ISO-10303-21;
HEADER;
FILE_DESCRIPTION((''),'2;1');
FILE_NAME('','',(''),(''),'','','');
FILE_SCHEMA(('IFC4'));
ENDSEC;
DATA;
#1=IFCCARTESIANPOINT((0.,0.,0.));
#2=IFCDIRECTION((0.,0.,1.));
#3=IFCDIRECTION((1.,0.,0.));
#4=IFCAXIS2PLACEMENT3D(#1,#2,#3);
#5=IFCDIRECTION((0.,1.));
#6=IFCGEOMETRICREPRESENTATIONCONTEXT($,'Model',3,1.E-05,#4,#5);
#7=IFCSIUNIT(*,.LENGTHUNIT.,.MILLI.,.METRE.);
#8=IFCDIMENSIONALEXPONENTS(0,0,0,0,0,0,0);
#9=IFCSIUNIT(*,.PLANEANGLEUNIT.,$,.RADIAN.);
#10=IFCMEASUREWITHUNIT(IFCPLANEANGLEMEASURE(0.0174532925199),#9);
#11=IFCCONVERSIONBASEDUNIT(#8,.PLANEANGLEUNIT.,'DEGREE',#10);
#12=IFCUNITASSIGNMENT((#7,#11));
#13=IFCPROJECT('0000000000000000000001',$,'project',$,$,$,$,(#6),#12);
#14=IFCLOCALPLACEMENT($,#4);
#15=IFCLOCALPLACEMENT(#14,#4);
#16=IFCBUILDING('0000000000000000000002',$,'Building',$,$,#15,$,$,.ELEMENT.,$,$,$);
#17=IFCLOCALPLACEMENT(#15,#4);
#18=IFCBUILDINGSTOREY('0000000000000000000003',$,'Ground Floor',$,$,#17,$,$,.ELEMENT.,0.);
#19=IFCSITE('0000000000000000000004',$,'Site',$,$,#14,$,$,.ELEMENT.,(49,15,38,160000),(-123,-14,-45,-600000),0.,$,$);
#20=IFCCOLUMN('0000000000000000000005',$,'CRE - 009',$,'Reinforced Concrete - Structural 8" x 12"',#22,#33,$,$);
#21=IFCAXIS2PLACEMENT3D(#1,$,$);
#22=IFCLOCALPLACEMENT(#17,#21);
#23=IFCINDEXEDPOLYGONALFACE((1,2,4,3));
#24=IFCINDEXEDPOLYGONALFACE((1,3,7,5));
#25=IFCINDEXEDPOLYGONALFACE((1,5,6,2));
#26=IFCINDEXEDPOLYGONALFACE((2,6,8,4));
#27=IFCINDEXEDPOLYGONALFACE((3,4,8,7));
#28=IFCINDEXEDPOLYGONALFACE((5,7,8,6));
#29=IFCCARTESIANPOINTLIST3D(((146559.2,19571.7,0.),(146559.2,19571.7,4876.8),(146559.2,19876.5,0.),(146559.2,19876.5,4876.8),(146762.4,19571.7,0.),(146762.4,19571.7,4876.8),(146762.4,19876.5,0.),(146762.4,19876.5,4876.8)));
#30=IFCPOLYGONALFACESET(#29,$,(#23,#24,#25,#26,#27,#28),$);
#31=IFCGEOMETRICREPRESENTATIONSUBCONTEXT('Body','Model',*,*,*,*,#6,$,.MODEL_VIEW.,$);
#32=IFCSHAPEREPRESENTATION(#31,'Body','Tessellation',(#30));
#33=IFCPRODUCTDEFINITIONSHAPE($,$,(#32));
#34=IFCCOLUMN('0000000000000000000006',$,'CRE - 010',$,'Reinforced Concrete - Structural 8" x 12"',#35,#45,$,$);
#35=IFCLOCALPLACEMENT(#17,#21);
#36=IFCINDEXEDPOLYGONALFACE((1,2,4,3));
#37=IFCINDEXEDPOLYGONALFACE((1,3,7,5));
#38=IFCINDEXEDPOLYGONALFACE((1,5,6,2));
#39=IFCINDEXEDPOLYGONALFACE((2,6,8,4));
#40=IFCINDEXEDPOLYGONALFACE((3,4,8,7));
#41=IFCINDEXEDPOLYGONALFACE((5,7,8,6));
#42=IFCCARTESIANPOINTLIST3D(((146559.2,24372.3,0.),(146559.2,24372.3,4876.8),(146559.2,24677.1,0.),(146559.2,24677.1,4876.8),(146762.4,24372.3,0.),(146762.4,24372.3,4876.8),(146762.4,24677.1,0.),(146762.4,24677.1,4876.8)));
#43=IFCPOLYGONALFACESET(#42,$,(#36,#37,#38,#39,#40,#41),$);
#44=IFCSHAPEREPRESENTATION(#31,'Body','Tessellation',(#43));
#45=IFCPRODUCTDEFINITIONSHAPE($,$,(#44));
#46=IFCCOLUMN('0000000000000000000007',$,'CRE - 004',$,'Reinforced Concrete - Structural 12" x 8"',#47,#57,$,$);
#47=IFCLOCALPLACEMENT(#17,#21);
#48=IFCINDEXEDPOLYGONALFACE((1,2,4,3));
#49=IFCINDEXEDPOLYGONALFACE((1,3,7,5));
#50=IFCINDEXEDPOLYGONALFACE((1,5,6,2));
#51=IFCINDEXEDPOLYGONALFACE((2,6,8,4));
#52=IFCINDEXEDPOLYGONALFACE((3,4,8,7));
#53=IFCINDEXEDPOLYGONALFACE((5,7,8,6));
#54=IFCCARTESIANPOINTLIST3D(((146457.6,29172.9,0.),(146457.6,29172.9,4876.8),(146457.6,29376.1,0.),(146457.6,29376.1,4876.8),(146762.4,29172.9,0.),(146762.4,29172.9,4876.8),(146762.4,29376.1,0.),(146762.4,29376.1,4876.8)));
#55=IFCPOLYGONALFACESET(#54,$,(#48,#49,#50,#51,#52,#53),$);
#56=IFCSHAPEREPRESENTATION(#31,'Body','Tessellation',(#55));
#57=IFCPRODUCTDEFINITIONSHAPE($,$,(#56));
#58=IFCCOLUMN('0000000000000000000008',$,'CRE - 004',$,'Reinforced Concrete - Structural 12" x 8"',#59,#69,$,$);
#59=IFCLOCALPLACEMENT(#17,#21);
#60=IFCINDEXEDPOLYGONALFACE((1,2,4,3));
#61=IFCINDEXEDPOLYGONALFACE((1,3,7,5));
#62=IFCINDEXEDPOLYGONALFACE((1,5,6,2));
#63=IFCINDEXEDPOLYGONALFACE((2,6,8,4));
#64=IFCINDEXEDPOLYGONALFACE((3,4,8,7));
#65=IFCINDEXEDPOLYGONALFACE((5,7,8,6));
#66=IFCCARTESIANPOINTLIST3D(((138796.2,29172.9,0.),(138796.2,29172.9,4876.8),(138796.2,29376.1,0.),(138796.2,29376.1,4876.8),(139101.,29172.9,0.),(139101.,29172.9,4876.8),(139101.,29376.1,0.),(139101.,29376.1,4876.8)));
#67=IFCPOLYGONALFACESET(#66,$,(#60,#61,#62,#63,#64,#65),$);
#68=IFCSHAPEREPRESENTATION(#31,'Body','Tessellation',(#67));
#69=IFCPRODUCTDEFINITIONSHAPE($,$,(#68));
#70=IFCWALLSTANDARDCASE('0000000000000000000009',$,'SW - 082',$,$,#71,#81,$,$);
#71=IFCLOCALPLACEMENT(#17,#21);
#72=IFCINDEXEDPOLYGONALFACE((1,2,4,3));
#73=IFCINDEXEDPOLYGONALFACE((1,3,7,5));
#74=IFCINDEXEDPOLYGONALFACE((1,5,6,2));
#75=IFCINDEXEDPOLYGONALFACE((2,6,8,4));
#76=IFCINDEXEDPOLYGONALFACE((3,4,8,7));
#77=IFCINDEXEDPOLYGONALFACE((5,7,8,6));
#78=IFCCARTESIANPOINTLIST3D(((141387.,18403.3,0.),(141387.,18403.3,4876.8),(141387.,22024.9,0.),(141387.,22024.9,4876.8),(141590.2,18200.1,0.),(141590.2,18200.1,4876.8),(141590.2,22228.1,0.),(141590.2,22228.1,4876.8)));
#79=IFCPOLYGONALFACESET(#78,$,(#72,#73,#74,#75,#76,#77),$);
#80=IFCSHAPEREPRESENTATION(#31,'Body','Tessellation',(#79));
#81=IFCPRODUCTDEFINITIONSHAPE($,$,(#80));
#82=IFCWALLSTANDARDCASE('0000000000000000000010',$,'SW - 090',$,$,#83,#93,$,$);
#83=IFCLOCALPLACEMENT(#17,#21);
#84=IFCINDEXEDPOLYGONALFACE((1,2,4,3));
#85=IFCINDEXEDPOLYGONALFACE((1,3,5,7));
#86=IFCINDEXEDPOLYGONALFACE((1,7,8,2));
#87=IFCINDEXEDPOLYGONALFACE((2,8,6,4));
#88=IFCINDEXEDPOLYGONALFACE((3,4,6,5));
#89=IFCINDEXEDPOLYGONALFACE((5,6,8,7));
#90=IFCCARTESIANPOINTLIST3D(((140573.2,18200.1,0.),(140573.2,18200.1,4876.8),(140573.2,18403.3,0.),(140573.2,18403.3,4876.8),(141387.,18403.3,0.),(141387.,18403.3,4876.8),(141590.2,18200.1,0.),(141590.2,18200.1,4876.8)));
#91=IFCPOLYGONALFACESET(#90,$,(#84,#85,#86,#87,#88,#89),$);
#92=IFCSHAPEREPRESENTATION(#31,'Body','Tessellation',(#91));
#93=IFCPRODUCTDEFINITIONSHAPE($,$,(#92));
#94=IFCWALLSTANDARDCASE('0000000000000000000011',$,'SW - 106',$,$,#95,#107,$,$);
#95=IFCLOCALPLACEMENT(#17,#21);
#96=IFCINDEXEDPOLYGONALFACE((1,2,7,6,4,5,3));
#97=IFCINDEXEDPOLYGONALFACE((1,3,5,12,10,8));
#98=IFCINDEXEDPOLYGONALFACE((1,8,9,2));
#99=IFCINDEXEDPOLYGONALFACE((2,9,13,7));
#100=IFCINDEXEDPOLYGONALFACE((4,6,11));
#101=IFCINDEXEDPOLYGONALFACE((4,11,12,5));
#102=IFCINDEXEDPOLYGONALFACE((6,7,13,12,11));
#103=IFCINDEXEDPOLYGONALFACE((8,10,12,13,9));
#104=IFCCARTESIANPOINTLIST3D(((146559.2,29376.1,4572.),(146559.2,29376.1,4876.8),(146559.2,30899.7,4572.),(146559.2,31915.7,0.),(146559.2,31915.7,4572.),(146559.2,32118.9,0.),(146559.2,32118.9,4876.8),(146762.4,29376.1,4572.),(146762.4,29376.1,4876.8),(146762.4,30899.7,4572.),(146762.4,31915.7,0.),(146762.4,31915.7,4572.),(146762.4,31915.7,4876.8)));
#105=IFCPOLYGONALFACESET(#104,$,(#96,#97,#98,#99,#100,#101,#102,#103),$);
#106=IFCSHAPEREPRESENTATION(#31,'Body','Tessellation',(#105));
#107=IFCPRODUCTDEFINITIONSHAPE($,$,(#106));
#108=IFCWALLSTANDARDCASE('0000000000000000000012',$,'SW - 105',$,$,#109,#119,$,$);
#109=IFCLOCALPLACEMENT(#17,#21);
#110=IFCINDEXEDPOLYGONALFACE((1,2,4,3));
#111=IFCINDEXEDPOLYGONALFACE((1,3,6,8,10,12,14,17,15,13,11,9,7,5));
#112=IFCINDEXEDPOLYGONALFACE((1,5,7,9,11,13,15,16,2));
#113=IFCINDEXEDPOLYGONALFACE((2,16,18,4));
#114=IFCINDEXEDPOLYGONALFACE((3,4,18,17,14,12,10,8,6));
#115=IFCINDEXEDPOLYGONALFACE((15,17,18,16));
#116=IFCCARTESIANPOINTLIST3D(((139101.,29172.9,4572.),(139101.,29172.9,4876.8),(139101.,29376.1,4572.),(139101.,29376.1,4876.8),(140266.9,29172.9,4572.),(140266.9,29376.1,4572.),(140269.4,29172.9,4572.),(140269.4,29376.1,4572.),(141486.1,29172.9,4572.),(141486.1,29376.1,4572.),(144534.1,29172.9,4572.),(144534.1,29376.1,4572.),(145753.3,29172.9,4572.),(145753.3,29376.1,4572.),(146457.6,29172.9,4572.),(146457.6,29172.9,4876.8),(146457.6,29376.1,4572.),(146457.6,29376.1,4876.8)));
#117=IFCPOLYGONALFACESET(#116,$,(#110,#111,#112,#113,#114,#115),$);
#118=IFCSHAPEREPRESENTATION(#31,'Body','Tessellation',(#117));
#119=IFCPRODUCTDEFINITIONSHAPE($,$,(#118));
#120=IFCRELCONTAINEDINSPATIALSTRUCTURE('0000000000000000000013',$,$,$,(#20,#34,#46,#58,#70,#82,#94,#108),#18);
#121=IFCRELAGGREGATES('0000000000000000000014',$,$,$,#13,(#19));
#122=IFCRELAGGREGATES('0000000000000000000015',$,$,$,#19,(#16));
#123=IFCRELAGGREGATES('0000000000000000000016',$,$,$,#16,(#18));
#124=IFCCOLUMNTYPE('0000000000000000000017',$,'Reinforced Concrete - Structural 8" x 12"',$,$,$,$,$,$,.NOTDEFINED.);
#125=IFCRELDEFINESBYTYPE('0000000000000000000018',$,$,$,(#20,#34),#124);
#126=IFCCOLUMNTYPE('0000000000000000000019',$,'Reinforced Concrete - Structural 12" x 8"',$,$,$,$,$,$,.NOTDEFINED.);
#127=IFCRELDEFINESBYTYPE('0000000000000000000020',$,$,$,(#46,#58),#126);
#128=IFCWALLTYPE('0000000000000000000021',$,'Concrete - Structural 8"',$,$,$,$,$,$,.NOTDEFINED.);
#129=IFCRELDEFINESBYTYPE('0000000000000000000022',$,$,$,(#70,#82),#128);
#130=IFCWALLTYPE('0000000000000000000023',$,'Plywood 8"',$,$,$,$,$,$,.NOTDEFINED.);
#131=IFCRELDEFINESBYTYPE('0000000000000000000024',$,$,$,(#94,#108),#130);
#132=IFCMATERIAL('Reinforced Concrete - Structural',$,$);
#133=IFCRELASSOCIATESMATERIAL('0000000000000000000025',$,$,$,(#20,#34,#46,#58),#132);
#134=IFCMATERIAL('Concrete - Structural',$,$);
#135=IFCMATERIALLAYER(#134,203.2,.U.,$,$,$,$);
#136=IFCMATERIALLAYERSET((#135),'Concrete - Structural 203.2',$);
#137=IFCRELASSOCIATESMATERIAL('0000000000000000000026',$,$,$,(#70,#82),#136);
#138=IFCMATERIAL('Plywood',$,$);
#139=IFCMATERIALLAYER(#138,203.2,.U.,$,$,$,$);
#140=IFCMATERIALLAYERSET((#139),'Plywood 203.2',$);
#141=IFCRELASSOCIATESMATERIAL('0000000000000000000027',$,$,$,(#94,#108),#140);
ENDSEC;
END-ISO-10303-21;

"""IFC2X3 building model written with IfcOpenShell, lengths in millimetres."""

from ifc_helpers import new_model, entity, si_unit, converted_unit, direction, frame, origin_with_axes, origin_2d_with_axis, place, context, subcontext, project, spatial, polyline, rectangle, outline, extrude, material, layer, layer_set, layer_usage, type_object, element, save


model = new_model("IFC2X3")

# Units and contexts
model_context = context("Model", 3, precision=1e-05, world=origin_with_axes(), true_north=direction((0.0, 1.0)))
body_context = subcontext(model_context, "Body", "Model", "MODEL_VIEW")
ifc_project = project(units=[si_unit("LENGTHUNIT", "METRE", prefix="MILLI"), converted_unit("PLANEANGLEUNIT", "DEGREE", entity("IfcPlaneAngleMeasure", 0.0174532925199), si_unit("PLANEANGLEUNIT", "RADIAN"), dimensions=[0, 0, 0, 0, 0, 0, 0])], contexts=[model_context])

# Site, building, storey
site_placement = place(None, origin_with_axes())
site = spatial("IfcSite", under=ifc_project, at=site_placement, Name="Site", CompositionType="ELEMENT", RefLatitude=(49, 15, 38, 160000), RefLongitude=(-123, -14, -45, -600000), RefElevation=0.0)
building_placement = place(site_placement, origin_with_axes())
building = spatial("IfcBuilding", under=site, at=building_placement, Name="Building", CompositionType="ELEMENT")
storey_placement = place(building_placement, origin_with_axes())
storey = spatial("IfcBuildingStorey", under=building, at=storey_placement, Name="Ground Floor", CompositionType="ELEMENT", Elevation=0.0)

# Columns
ifc_material_1 = material(Name="Reinforced Concrete - Structural")
column_type_1 = type_object("IfcColumnType", Name="Reinforced Concrete - Structural 8\" x 12\"", PredefinedType="NOTDEFINED")
for number, where, z_axis, x_axis, name in (
    (1, (146660.8, 19724.1, 0.0), (0.0, 0.0, 1.0), (1.0, 0.0, 0.0), "CRE - 009"),
    (2, (146660.8, 24524.7, 0.0), (0.0, 0.0, 1.0), (1.0, 0.0, 0.0), "CRE - 010"),
):
    element("IfcColumn", number, at=place(storey_placement, frame(where, z_axis=z_axis, x_axis=x_axis)), inside=storey, type_object=column_type_1, material=ifc_material_1, Name=name, ObjectType="Reinforced Concrete - Structural 8\" x 12\"", context=body_context, shape_type="SweptSolid", body=[
        extrude(rectangle(XDim=203.2, YDim=304.8, at=origin_2d_with_axis()), origin_with_axes(), (0.0, 0.0, 1.0), 4876.8),
    ])
column_type_2 = type_object("IfcColumnType", Name="Reinforced Concrete - Structural 12\" x 8\"", PredefinedType="NOTDEFINED")
for number, where, z_axis, x_axis, name in (
    (3, (146610.0, 29274.5, 0.0), (0.0, 0.0, 1.0), (1.0, 0.0, 0.0), "CRE - 004"),
    (4, (138948.6, 29274.5, 0.0), (0.0, 0.0, 1.0), (1.0, 0.0, 0.0), "CRE - 004"),
):
    element("IfcColumn", number, at=place(storey_placement, frame(where, z_axis=z_axis, x_axis=x_axis)), inside=storey, type_object=column_type_2, material=ifc_material_1, Name=name, ObjectType="Reinforced Concrete - Structural 12\" x 8\"", context=body_context, shape_type="SweptSolid", body=[
        extrude(rectangle(XDim=304.8, YDim=203.2, at=origin_2d_with_axis()), origin_with_axes(), (0.0, 0.0, 1.0), 4876.8),
    ])

# Walls
ifc_material_2 = material(Name="Concrete - Structural")
ifc_layer_1 = layer(ifc_material_2, 203.2, ventilated="UNKNOWN")
ifc_layer_set_1 = layer_set([ifc_layer_1], Name="Concrete - Structural 203.2")
ifc_layer_usage_1 = layer_usage(ifc_layer_set_1, "AXIS2", "POSITIVE", 0.0)
wall_type_1 = type_object("IfcWallType", Name="Concrete - Structural 8\"", PredefinedType="NOTDEFINED")
wall_1_placement = place(storey_placement, frame((141387.0, 22024.9, 0.0), z_axis=(0.0, 0.0, 1.0), x_axis=(0.0, -1.0, 0.0)))
element("IfcWallStandardCase", 5, at=wall_1_placement, inside=storey, type_object=wall_type_1, material=ifc_layer_usage_1, Name="SW - 082", context=body_context, shape_type="SweptSolid", body=[
    extrude(outline(polyline([(0.0, 0.0), (3621.6, 0.0), (3824.8, 203.2), (-203.2, 203.2), (0.0, 0.0)])), origin_with_axes(), (0.0, 0.0, 1.0), 4876.8),
])
ifc_layer_usage_2 = layer_usage(ifc_layer_set_1, "AXIS2", "POSITIVE", 0.0)
wall_2_placement = place(storey_placement, frame((141387.0, 18403.3, 0.0), z_axis=(0.0, 0.0, 1.0), x_axis=(-1.0, 0.0, 0.0)))
element("IfcWallStandardCase", 6, at=wall_2_placement, inside=storey, type_object=wall_type_1, material=ifc_layer_usage_2, Name="SW - 090", context=body_context, shape_type="SweptSolid", body=[
    extrude(outline(polyline([(0.0, 0.0), (813.8, 0.0), (813.8, 203.2), (-203.2, 203.2), (0.0, 0.0)])), origin_with_axes(), (0.0, 0.0, 1.0), 4876.8),
])

# Walls, openings
ifc_material_3 = material(Name="Plywood")
ifc_layer_2 = layer(ifc_material_3, 203.2, ventilated="UNKNOWN")
ifc_layer_set_2 = layer_set([ifc_layer_2], Name="Plywood 203.2")
ifc_layer_usage_3 = layer_usage(ifc_layer_set_2, "AXIS2", "POSITIVE", 0.0)
wall_type_2 = type_object("IfcWallType", Name="Plywood 8\"", PredefinedType="NOTDEFINED")
wall_3_placement = place(storey_placement, frame((146762.4, 29376.1, 0.0), z_axis=(0.0, 0.0, 1.0), x_axis=(0.0, 1.0, 0.0)))
wall_3 = element("IfcWallStandardCase", 7, at=wall_3_placement, inside=storey, type_object=wall_type_2, material=ifc_layer_usage_3, Name="SW - 106", context=body_context, shape_type="SweptSolid", body=[
    extrude(outline(polyline([(0.0, 0.0), (2539.7, 0.0), (2742.9, 203.2), (0.0, 203.2), (0.0, 0.0)])), origin_with_axes(), (0.0, 0.0, 1.0), 4876.8),
])
opening_1_placement = place(wall_3_placement, frame((2031.7, 0.0, 0.0), z_axis=(0.0, 0.0, 1.0), x_axis=(1.0, 0.0, 0.0)))
element("IfcOpeningElement", 8, at=opening_1_placement, cuts=wall_3, context=body_context, shape_type="SweptSolid", body=[
    extrude(rectangle(XDim=1016.0, YDim=4572.0, at=origin_2d_with_axis()), frame((0.0, -203.2, 2286.0), z_axis=(0.0, -1.0, 0.0), x_axis=(-1.0, 0.0, 0.0)), (0.0, 0.0, -1.0), 609.6),
])
opening_2_placement = place(wall_3_placement, frame((761.8, 0.0, 0.0), z_axis=(0.0, 0.0, 1.0), x_axis=(1.0, 0.0, 0.0)))
element("IfcOpeningElement", 9, at=opening_2_placement, cuts=wall_3, context=body_context, shape_type="SweptSolid", body=[
    extrude(rectangle(XDim=1523.7, YDim=4572.0, at=origin_2d_with_axis()), frame((0.0, -203.2, 2286.0), z_axis=(0.0, 1.0, 0.0), x_axis=(1.0, 0.0, 0.0)), (0.0, 0.0, 1.0), 609.6),
])
ifc_layer_usage_4 = layer_usage(ifc_layer_set_2, "AXIS2", "POSITIVE", 0.0)
wall_4_placement = place(storey_placement, frame((139101.0, 29172.9, 0.0), z_axis=(0.0, 0.0, 1.0), x_axis=(1.0, 0.0, 0.0)))
wall_4 = element("IfcWallStandardCase", 10, at=wall_4_placement, inside=storey, type_object=wall_type_2, material=ifc_layer_usage_4, Name="SW - 105", context=body_context, shape_type="SweptSolid", body=[
    extrude(outline(polyline([(0.0, 0.0), (7356.6, 0.0), (7356.6, 203.2), (0.0, 203.2), (0.0, 0.0)])), origin_with_axes(), (0.0, 0.0, 1.0), 4876.8),
])
opening_3_placement = place(wall_4_placement, frame((7004.4, 0.0, 0.0), z_axis=(0.0, 0.0, 1.0), x_axis=(1.0, 0.0, 0.0)))
element("IfcOpeningElement", 11, at=opening_3_placement, cuts=wall_4, context=body_context, shape_type="SweptSolid", body=[
    extrude(rectangle(XDim=704.4, YDim=4572.0, at=origin_2d_with_axis()), frame((0.0, -203.2, 2286.0), z_axis=(0.0, 1.0, 0.0), x_axis=(1.0, 0.0, 0.0)), (0.0, 0.0, 1.0), 609.6),
])
opening_4_placement = place(wall_4_placement, frame((6042.6, 0.0, 0.0), z_axis=(0.0, 0.0, 1.0), x_axis=(1.0, 0.0, 0.0)))
element("IfcOpeningElement", 12, at=opening_4_placement, cuts=wall_4, context=body_context, shape_type="SweptSolid", body=[
    extrude(rectangle(XDim=1219.2, YDim=4572.0, at=origin_2d_with_axis()), frame((0.0, -203.2, 2286.0), z_axis=(0.0, -1.0, 0.0), x_axis=(-1.0, 0.0, 0.0)), (0.0, 0.0, -1.0), 609.6),
])
opening_5_placement = place(wall_4_placement, frame((1775.4, 0.0, 0.0), z_axis=(0.0, 0.0, 1.0), x_axis=(1.0, 0.0, 0.0)))
element("IfcOpeningElement", 13, at=opening_5_placement, cuts=wall_4, context=body_context, shape_type="SweptSolid", body=[
    extrude(rectangle(XDim=1219.2, YDim=4572.0, at=origin_2d_with_axis()), frame((0.0, -203.2, 2286.0), z_axis=(0.0, 1.0, 0.0), x_axis=(1.0, 0.0, 0.0)), (0.0, 0.0, 1.0), 609.6),
])
opening_6_placement = place(wall_4_placement, frame((584.2, 0.0, 0.0), z_axis=(0.0, 0.0, 1.0), x_axis=(1.0, 0.0, 0.0)))
element("IfcOpeningElement", 14, at=opening_6_placement, cuts=wall_4, context=body_context, shape_type="SweptSolid", body=[
    extrude(rectangle(XDim=1168.4, YDim=4572.0, at=origin_2d_with_axis()), frame((0.0, -203.2, 2286.0), z_axis=(0.0, 1.0, 0.0), x_axis=(1.0, 0.0, 0.0)), (0.0, 0.0, 1.0), 609.6),
])
opening_7_placement = place(wall_4_placement, frame((3909.0, 0.0, 0.0), z_axis=(0.0, 0.0, 1.0), x_axis=(1.0, 0.0, 0.0)))
element("IfcOpeningElement", 15, at=opening_7_placement, cuts=wall_4, context=body_context, shape_type="SweptSolid", body=[
    extrude(rectangle(XDim=3048.0, YDim=4572.0, at=origin_2d_with_axis()), frame((0.0, -203.2, 2286.0), z_axis=(0.0, 1.0, 0.0), x_axis=(1.0, 0.0, 0.0)), (0.0, 0.0, 1.0), 609.6),
])

save(model, "model.ifc")
